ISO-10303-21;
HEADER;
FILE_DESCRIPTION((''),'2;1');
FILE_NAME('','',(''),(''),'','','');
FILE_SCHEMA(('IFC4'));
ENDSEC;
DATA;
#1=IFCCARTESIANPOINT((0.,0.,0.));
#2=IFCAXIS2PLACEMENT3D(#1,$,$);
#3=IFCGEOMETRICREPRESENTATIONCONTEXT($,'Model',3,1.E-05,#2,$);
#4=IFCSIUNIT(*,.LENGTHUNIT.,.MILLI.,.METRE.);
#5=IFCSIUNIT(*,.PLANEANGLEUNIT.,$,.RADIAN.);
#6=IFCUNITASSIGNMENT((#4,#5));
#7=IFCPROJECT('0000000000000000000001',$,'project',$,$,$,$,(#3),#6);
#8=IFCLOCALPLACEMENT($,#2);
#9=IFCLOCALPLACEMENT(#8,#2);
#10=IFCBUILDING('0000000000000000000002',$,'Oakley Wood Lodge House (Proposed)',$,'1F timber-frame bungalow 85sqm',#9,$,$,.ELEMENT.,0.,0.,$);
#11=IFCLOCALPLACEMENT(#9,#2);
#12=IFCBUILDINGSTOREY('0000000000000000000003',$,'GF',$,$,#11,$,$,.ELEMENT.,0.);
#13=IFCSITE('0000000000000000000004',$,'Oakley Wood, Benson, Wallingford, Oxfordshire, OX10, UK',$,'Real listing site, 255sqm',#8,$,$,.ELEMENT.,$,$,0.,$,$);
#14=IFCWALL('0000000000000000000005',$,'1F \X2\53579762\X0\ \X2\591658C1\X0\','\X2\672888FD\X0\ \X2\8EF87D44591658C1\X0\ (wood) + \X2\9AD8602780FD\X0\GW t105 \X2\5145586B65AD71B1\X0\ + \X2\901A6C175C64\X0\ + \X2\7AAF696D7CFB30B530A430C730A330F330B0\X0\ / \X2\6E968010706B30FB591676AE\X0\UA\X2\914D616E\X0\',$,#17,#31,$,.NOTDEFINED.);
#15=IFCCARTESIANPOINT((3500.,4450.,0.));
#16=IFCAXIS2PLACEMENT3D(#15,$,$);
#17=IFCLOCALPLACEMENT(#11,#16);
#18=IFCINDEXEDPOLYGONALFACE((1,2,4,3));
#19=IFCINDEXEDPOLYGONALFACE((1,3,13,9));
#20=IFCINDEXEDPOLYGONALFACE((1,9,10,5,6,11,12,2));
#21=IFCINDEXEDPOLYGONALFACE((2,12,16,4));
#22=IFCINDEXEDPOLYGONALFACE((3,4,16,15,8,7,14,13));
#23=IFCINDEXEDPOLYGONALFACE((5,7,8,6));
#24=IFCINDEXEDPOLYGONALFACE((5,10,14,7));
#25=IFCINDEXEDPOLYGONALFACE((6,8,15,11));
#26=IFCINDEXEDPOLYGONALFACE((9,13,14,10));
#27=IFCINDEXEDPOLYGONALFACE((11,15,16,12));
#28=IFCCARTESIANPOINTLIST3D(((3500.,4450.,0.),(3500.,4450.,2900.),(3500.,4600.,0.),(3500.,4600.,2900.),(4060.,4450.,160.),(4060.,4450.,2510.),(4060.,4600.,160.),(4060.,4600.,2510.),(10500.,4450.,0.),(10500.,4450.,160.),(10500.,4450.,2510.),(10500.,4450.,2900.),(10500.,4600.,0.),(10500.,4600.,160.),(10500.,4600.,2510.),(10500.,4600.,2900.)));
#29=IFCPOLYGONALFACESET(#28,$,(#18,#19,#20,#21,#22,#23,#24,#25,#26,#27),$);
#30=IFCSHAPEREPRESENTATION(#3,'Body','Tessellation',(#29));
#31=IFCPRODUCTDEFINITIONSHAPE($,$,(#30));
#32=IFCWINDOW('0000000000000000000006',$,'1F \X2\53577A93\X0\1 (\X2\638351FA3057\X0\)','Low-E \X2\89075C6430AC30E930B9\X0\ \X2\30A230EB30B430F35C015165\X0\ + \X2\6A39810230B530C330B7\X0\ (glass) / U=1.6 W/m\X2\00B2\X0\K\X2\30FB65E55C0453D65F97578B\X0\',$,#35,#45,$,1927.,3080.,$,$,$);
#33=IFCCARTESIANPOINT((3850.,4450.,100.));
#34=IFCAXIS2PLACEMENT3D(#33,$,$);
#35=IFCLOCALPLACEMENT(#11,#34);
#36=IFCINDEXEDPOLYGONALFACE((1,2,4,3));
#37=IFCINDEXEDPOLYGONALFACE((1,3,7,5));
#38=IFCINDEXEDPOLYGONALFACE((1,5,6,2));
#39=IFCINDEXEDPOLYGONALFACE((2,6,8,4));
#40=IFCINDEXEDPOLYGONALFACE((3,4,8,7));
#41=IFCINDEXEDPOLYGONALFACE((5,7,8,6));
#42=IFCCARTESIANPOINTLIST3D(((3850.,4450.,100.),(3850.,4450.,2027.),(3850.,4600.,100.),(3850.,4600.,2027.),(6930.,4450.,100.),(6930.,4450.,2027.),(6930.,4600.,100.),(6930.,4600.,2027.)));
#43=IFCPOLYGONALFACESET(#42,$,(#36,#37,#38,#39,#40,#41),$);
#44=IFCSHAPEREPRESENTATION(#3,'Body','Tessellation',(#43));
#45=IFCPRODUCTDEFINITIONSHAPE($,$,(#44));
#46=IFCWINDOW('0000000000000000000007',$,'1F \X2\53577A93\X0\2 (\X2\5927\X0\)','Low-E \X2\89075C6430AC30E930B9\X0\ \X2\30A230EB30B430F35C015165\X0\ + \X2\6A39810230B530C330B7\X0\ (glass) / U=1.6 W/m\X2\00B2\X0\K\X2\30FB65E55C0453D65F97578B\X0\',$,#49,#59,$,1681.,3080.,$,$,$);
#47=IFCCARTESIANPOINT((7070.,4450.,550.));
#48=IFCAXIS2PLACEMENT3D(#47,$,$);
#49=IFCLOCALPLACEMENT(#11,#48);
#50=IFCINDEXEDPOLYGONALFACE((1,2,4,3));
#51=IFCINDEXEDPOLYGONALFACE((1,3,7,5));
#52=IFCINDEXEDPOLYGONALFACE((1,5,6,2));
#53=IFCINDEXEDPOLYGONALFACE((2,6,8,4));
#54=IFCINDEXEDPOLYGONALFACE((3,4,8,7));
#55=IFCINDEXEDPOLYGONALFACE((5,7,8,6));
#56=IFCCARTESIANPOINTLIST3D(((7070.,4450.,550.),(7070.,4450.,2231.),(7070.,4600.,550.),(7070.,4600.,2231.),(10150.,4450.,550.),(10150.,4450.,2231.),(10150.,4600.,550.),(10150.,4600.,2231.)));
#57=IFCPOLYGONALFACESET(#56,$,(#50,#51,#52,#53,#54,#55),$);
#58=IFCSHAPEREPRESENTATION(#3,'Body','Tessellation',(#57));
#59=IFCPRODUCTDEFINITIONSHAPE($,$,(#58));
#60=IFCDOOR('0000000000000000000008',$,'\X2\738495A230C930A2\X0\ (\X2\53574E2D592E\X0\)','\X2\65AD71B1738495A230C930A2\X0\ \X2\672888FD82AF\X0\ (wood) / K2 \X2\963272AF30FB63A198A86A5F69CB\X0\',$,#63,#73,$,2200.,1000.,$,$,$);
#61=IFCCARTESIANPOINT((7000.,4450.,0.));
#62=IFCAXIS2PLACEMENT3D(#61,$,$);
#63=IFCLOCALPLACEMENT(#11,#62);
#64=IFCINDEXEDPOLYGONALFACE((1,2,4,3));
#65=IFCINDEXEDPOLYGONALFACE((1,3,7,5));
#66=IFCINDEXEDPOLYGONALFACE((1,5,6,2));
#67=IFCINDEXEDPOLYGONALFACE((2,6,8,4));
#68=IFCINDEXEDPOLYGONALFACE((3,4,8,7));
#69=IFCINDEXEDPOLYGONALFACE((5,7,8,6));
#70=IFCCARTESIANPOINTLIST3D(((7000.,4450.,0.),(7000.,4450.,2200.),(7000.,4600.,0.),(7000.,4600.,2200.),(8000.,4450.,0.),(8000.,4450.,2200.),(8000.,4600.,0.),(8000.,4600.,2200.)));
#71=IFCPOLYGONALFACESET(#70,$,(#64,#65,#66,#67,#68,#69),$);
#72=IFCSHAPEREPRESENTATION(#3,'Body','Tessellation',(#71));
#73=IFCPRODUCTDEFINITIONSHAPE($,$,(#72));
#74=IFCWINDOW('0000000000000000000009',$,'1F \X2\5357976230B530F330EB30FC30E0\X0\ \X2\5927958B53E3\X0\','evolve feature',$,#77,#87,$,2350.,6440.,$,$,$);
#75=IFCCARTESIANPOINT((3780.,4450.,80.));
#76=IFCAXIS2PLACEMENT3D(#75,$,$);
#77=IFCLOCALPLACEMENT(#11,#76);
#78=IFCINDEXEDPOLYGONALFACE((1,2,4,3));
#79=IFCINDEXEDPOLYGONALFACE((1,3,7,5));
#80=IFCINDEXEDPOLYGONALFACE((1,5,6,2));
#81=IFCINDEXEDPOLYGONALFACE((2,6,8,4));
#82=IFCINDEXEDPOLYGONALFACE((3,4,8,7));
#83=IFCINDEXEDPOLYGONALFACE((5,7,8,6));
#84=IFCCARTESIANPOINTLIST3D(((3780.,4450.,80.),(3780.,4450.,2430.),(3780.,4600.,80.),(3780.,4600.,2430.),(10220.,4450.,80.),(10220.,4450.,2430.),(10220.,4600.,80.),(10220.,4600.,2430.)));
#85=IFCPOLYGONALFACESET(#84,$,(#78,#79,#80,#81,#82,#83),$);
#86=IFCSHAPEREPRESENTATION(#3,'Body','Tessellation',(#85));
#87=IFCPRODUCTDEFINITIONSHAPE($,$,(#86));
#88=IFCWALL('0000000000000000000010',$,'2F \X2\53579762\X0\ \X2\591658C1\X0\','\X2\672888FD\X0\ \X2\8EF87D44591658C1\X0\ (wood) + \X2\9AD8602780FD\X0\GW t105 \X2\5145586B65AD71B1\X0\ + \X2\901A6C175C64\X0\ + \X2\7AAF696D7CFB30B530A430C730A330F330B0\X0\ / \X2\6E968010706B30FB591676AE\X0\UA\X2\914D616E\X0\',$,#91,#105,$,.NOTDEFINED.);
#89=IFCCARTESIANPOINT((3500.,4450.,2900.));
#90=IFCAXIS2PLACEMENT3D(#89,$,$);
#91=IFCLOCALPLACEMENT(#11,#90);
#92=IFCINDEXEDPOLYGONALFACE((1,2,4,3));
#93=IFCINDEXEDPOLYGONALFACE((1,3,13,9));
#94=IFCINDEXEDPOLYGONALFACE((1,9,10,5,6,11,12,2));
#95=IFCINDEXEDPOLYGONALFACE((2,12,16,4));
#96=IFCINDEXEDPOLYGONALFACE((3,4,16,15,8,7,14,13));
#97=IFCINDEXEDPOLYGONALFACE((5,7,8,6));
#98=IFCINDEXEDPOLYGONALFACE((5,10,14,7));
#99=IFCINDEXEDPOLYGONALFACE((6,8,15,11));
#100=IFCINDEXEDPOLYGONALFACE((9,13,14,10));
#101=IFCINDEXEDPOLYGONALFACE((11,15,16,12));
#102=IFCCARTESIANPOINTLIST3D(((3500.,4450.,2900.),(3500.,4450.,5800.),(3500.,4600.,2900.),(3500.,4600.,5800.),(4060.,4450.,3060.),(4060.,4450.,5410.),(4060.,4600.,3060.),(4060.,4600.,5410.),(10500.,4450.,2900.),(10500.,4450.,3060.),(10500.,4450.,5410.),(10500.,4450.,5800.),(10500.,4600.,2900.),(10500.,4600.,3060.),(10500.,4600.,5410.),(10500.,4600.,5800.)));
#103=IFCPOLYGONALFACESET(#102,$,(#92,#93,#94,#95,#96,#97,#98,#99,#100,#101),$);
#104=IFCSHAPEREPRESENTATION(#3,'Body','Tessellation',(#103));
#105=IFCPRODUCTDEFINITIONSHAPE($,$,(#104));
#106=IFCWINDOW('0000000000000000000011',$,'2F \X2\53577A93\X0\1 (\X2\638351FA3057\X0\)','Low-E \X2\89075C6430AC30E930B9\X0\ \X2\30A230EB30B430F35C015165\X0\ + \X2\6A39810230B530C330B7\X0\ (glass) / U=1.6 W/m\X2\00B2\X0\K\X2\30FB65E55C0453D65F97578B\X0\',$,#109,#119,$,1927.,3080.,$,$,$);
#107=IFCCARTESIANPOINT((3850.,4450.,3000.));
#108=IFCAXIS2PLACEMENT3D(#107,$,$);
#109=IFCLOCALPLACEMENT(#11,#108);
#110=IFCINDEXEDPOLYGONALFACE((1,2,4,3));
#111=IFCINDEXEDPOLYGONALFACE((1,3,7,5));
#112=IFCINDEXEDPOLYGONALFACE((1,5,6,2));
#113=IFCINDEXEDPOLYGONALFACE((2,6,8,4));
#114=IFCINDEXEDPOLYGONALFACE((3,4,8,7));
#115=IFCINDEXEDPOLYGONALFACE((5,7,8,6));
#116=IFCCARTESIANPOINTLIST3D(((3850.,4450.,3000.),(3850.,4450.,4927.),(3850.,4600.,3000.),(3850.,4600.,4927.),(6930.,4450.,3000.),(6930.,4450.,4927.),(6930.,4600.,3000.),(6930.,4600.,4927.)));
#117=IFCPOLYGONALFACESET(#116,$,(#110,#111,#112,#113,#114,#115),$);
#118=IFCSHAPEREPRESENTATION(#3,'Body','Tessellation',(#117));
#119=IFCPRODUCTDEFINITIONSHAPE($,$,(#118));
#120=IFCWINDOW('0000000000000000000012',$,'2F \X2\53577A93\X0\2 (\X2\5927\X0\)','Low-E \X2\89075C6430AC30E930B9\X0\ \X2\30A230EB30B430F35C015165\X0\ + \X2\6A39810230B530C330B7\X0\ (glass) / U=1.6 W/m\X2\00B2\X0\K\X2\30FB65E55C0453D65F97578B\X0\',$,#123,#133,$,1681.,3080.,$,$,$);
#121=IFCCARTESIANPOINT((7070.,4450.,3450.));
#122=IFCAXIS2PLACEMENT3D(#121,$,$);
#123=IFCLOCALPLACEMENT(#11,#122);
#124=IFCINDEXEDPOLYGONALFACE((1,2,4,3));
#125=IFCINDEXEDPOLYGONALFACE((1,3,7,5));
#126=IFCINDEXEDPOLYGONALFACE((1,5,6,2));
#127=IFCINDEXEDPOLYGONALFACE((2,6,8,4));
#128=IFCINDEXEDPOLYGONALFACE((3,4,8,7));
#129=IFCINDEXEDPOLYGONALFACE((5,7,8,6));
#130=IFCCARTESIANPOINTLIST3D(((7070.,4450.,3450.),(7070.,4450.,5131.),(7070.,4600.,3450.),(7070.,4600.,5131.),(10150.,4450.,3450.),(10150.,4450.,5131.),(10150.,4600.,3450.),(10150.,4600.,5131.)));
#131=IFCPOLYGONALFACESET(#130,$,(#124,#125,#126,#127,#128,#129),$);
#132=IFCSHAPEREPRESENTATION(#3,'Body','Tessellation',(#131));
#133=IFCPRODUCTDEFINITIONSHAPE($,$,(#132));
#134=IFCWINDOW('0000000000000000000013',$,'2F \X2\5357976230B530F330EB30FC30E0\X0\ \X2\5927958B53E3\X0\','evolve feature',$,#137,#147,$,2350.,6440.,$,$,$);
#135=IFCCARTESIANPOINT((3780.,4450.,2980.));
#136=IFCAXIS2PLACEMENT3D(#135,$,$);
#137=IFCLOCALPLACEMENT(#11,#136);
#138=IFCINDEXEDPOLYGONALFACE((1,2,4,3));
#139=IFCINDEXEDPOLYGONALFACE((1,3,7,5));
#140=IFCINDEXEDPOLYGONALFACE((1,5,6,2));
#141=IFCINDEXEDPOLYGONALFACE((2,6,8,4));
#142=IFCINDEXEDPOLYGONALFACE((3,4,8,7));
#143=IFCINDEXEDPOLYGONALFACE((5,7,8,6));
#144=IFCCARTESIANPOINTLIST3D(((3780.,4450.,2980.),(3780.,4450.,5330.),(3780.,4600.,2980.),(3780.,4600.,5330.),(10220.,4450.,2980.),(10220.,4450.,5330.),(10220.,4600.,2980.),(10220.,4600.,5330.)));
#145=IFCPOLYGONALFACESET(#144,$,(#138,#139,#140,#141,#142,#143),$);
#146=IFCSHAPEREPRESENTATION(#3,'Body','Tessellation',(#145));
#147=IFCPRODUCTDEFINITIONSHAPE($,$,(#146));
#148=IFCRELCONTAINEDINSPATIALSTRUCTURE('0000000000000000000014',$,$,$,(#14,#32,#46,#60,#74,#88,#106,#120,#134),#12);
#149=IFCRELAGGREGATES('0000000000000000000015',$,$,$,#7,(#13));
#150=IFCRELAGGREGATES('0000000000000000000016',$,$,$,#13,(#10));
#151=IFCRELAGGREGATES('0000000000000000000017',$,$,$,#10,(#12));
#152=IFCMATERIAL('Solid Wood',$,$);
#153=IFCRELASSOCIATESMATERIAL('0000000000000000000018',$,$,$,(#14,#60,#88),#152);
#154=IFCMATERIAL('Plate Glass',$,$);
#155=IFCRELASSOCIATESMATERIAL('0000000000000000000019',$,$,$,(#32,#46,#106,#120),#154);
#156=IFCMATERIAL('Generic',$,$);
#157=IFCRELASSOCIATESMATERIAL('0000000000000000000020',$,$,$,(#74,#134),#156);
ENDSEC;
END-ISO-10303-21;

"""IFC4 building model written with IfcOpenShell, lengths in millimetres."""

from ifc_helpers import new_model, si_unit, frame, frame_2d, origin, place, context, project, spatial, rectangle, extrude, material, element, fill, save


model = new_model("IFC4")

# Units and contexts
model_context = context("Model", 3, precision=1e-05, world=origin())
ifc_project = project(units=[si_unit("LENGTHUNIT", "METRE", prefix="MILLI"), si_unit("PLANEANGLEUNIT", "RADIAN")], contexts=[model_context])

# Site, building, storey
site_placement = place(None, origin())
site = spatial("IfcSite", under=ifc_project, at=site_placement, Name="Oakley Wood, Benson, Wallingford, Oxfordshire, OX10, UK", ObjectType="Real listing site, 255sqm", CompositionType="ELEMENT", RefElevation=0.0)
building_placement = place(site_placement, origin())
building = spatial("IfcBuilding", under=site, at=building_placement, Name="Oakley Wood Lodge House (Proposed)", ObjectType="1F timber-frame bungalow 85sqm", CompositionType="ELEMENT", ElevationOfRefHeight=0.0, ElevationOfTerrain=0.0)
storey_placement = place(building_placement, origin())
storey = spatial("IfcBuildingStorey", under=building, at=storey_placement, Name="GF", CompositionType="ELEMENT", Elevation=0.0)

# Shared definitions
ifc_material_1 = material(Name="Solid Wood")
ifc_material_2 = material(Name="Generic")

# Wall, openings, windows, door
wall_1_placement = place(storey_placement, frame((3500.0, 4450.0, 0.0)))
wall_1 = element("IfcWall", 1, at=wall_1_placement, inside=storey, material=ifc_material_1, Name="1F 南面 外壁", Description="木製 軸組外壁 (wood) + 高性能GW t105 充填断熱 + 通気層 + 窯業系サイディング / 準耐火・外皮UA配慮", PredefinedType="NOTDEFINED", context=model_context, shape_type="SweptSolid", body=[
    extrude(rectangle(XDim=7000.0, YDim=150.0, at=frame_2d((3500.0, 75.0))), frame((3500.0, 4450.0, 0.0)), (0.0, 0.0, 1.0), 2900.0),
])
opening_1_placement = place(storey_placement, frame((3850.0, 4450.0, 100.0)))
opening_1 = element("IfcOpeningElement", 2, at=opening_1_placement, cuts=wall_1, PredefinedType="NOTDEFINED", context=model_context, shape_type="SweptSolid", body=[
    extrude(rectangle(XDim=3080.0, YDim=150.0, at=frame_2d((1540.0, 75.0))), frame((3850.0, 4450.0, 100.0)), (0.0, 0.0, 1.0), 1927.0),
])
opening_2_placement = place(storey_placement, frame((7070.0, 4450.0, 550.0)))
opening_2 = element("IfcOpeningElement", 3, at=opening_2_placement, cuts=wall_1, PredefinedType="NOTDEFINED", context=model_context, shape_type="SweptSolid", body=[
    extrude(rectangle(XDim=3080.0, YDim=150.0, at=frame_2d((1540.0, 75.0))), frame((7070.0, 4450.0, 550.0)), (0.0, 0.0, 1.0), 1681.0),
])
opening_3_placement = place(storey_placement, frame((7000.0, 4450.0, 0.0)))
opening_3 = element("IfcOpeningElement", 4, at=opening_3_placement, cuts=wall_1, PredefinedType="NOTDEFINED", context=model_context, shape_type="SweptSolid", body=[
    extrude(rectangle(XDim=1000.0, YDim=150.0, at=frame_2d((500.0, 75.0))), frame((7000.0, 4450.0, 0.0)), (0.0, 0.0, 1.0), 2200.0),
])
opening_4_placement = place(storey_placement, frame((3780.0, 4450.0, 80.0)))
opening_4 = element("IfcOpeningElement", 5, at=opening_4_placement, cuts=wall_1, PredefinedType="NOTDEFINED", context=model_context, shape_type="SweptSolid", body=[
    extrude(rectangle(XDim=6440.0, YDim=150.0, at=frame_2d((3220.0, 75.0))), frame((3780.0, 4450.0, 80.0)), (0.0, 0.0, 1.0), 2350.0),
])
ifc_material_3 = material(Name="Plate Glass")
window_1_placement = place(storey_placement, frame((3850.0, 4450.0, 100.0)))
window_1 = element("IfcWindow", 6, at=window_1_placement, inside=storey, material=ifc_material_3, Name="1F 南窓1 (掃出し)", Description="Low-E 複層ガラス アルゴン封入 + 樹脂サッシ (glass) / U=1.6 W/m²K・日射取得型", OverallHeight=1927.0, OverallWidth=3080.0, context=model_context, shape_type="SweptSolid", body=[
    extrude(rectangle(XDim=3080.0, YDim=150.0, at=frame_2d((1540.0, 75.0))), frame((3850.0, 4450.0, 100.0)), (0.0, 0.0, 1.0), 1927.0),
])
fill(opening_1, window_1)
window_2_placement = place(storey_placement, frame((7070.0, 4450.0, 550.0)))
window_2 = element("IfcWindow", 7, at=window_2_placement, inside=storey, material=ifc_material_3, Name="1F 南窓2 (大)", Description="Low-E 複層ガラス アルゴン封入 + 樹脂サッシ (glass) / U=1.6 W/m²K・日射取得型", OverallHeight=1681.0, OverallWidth=3080.0, context=model_context, shape_type="SweptSolid", body=[
    extrude(rectangle(XDim=3080.0, YDim=150.0, at=frame_2d((1540.0, 75.0))), frame((7070.0, 4450.0, 550.0)), (0.0, 0.0, 1.0), 1681.0),
])
fill(opening_2, window_2)
door_placement = place(storey_placement, frame((7000.0, 4450.0, 0.0)))
door = element("IfcDoor", 8, at=door_placement, inside=storey, material=ifc_material_1, Name="玄関ドア (南中央)", Description="断熱玄関ドア 木製芯 (wood) / K2 防犯・採風機構", OverallHeight=2200.0, OverallWidth=1000.0, context=model_context, shape_type="SweptSolid", body=[
    extrude(rectangle(XDim=1000.0, YDim=150.0, at=frame_2d((500.0, 75.0))), frame((7000.0, 4450.0, 0.0)), (0.0, 0.0, 1.0), 2200.0),
])
fill(opening_3, door)
window_3_placement = place(storey_placement, frame((3780.0, 4450.0, 80.0)))
window_3 = element("IfcWindow", 9, at=window_3_placement, inside=storey, material=ifc_material_2, Name="1F 南面サンルーム 大開口", Description="evolve feature", OverallHeight=2350.0, OverallWidth=6440.0, context=model_context, shape_type="SweptSolid", body=[
    extrude(rectangle(XDim=6440.0, YDim=150.0, at=frame_2d((3220.0, 75.0))), frame((3780.0, 4450.0, 80.0)), (0.0, 0.0, 1.0), 2350.0),
])
fill(opening_4, window_3)

# Wall, openings, windows
wall_2_placement = place(storey_placement, frame((3500.0, 4450.0, 2900.0)))
wall_2 = element("IfcWall", 10, at=wall_2_placement, inside=storey, material=ifc_material_1, Name="2F 南面 外壁", Description="木製 軸組外壁 (wood) + 高性能GW t105 充填断熱 + 通気層 + 窯業系サイディング / 準耐火・外皮UA配慮", PredefinedType="NOTDEFINED", context=model_context, shape_type="SweptSolid", body=[
    extrude(rectangle(XDim=7000.0, YDim=150.0, at=frame_2d((3500.0, 75.0))), frame((3500.0, 4450.0, 2900.0)), (0.0, 0.0, 1.0), 2900.0),
])
opening_5_placement = place(storey_placement, frame((3850.0, 4450.0, 3000.0)))
opening_5 = element("IfcOpeningElement", 11, at=opening_5_placement, cuts=wall_2, PredefinedType="NOTDEFINED", context=model_context, shape_type="SweptSolid", body=[
    extrude(rectangle(XDim=3080.0, YDim=150.0, at=frame_2d((1540.0, 75.0))), frame((3850.0, 4450.0, 3000.0)), (0.0, 0.0, 1.0), 1927.0),
])
opening_6_placement = place(storey_placement, frame((7070.0, 4450.0, 3450.0)))
opening_6 = element("IfcOpeningElement", 12, at=opening_6_placement, cuts=wall_2, PredefinedType="NOTDEFINED", context=model_context, shape_type="SweptSolid", body=[
    extrude(rectangle(XDim=3080.0, YDim=150.0, at=frame_2d((1540.0, 75.0))), frame((7070.0, 4450.0, 3450.0)), (0.0, 0.0, 1.0), 1681.0),
])
opening_7_placement = place(storey_placement, frame((3780.0, 4450.0, 2980.0)))
opening_7 = element("IfcOpeningElement", 13, at=opening_7_placement, cuts=wall_2, PredefinedType="NOTDEFINED", context=model_context, shape_type="SweptSolid", body=[
    extrude(rectangle(XDim=6440.0, YDim=150.0, at=frame_2d((3220.0, 75.0))), frame((3780.0, 4450.0, 2980.0)), (0.0, 0.0, 1.0), 2350.0),
])
window_4_placement = place(storey_placement, frame((3850.0, 4450.0, 3000.0)))
window_4 = element("IfcWindow", 14, at=window_4_placement, inside=storey, material=ifc_material_3, Name="2F 南窓1 (掃出し)", Description="Low-E 複層ガラス アルゴン封入 + 樹脂サッシ (glass) / U=1.6 W/m²K・日射取得型", OverallHeight=1927.0, OverallWidth=3080.0, context=model_context, shape_type="SweptSolid", body=[
    extrude(rectangle(XDim=3080.0, YDim=150.0, at=frame_2d((1540.0, 75.0))), frame((3850.0, 4450.0, 3000.0)), (0.0, 0.0, 1.0), 1927.0),
])
fill(opening_5, window_4)
window_5_placement = place(storey_placement, frame((7070.0, 4450.0, 3450.0)))
window_5 = element("IfcWindow", 15, at=window_5_placement, inside=storey, material=ifc_material_3, Name="2F 南窓2 (大)", Description="Low-E 複層ガラス アルゴン封入 + 樹脂サッシ (glass) / U=1.6 W/m²K・日射取得型", OverallHeight=1681.0, OverallWidth=3080.0, context=model_context, shape_type="SweptSolid", body=[
    extrude(rectangle(XDim=3080.0, YDim=150.0, at=frame_2d((1540.0, 75.0))), frame((7070.0, 4450.0, 3450.0)), (0.0, 0.0, 1.0), 1681.0),
])
fill(opening_6, window_5)
window_6_placement = place(storey_placement, frame((3780.0, 4450.0, 2980.0)))
window_6 = element("IfcWindow", 16, at=window_6_placement, inside=storey, material=ifc_material_2, Name="2F 南面サンルーム 大開口", Description="evolve feature", OverallHeight=2350.0, OverallWidth=6440.0, context=model_context, shape_type="SweptSolid", body=[
    extrude(rectangle(XDim=6440.0, YDim=150.0, at=frame_2d((3220.0, 75.0))), frame((3780.0, 4450.0, 2980.0)), (0.0, 0.0, 1.0), 2350.0),
])
fill(opening_7, window_6)

save(model, "model.ifc")
